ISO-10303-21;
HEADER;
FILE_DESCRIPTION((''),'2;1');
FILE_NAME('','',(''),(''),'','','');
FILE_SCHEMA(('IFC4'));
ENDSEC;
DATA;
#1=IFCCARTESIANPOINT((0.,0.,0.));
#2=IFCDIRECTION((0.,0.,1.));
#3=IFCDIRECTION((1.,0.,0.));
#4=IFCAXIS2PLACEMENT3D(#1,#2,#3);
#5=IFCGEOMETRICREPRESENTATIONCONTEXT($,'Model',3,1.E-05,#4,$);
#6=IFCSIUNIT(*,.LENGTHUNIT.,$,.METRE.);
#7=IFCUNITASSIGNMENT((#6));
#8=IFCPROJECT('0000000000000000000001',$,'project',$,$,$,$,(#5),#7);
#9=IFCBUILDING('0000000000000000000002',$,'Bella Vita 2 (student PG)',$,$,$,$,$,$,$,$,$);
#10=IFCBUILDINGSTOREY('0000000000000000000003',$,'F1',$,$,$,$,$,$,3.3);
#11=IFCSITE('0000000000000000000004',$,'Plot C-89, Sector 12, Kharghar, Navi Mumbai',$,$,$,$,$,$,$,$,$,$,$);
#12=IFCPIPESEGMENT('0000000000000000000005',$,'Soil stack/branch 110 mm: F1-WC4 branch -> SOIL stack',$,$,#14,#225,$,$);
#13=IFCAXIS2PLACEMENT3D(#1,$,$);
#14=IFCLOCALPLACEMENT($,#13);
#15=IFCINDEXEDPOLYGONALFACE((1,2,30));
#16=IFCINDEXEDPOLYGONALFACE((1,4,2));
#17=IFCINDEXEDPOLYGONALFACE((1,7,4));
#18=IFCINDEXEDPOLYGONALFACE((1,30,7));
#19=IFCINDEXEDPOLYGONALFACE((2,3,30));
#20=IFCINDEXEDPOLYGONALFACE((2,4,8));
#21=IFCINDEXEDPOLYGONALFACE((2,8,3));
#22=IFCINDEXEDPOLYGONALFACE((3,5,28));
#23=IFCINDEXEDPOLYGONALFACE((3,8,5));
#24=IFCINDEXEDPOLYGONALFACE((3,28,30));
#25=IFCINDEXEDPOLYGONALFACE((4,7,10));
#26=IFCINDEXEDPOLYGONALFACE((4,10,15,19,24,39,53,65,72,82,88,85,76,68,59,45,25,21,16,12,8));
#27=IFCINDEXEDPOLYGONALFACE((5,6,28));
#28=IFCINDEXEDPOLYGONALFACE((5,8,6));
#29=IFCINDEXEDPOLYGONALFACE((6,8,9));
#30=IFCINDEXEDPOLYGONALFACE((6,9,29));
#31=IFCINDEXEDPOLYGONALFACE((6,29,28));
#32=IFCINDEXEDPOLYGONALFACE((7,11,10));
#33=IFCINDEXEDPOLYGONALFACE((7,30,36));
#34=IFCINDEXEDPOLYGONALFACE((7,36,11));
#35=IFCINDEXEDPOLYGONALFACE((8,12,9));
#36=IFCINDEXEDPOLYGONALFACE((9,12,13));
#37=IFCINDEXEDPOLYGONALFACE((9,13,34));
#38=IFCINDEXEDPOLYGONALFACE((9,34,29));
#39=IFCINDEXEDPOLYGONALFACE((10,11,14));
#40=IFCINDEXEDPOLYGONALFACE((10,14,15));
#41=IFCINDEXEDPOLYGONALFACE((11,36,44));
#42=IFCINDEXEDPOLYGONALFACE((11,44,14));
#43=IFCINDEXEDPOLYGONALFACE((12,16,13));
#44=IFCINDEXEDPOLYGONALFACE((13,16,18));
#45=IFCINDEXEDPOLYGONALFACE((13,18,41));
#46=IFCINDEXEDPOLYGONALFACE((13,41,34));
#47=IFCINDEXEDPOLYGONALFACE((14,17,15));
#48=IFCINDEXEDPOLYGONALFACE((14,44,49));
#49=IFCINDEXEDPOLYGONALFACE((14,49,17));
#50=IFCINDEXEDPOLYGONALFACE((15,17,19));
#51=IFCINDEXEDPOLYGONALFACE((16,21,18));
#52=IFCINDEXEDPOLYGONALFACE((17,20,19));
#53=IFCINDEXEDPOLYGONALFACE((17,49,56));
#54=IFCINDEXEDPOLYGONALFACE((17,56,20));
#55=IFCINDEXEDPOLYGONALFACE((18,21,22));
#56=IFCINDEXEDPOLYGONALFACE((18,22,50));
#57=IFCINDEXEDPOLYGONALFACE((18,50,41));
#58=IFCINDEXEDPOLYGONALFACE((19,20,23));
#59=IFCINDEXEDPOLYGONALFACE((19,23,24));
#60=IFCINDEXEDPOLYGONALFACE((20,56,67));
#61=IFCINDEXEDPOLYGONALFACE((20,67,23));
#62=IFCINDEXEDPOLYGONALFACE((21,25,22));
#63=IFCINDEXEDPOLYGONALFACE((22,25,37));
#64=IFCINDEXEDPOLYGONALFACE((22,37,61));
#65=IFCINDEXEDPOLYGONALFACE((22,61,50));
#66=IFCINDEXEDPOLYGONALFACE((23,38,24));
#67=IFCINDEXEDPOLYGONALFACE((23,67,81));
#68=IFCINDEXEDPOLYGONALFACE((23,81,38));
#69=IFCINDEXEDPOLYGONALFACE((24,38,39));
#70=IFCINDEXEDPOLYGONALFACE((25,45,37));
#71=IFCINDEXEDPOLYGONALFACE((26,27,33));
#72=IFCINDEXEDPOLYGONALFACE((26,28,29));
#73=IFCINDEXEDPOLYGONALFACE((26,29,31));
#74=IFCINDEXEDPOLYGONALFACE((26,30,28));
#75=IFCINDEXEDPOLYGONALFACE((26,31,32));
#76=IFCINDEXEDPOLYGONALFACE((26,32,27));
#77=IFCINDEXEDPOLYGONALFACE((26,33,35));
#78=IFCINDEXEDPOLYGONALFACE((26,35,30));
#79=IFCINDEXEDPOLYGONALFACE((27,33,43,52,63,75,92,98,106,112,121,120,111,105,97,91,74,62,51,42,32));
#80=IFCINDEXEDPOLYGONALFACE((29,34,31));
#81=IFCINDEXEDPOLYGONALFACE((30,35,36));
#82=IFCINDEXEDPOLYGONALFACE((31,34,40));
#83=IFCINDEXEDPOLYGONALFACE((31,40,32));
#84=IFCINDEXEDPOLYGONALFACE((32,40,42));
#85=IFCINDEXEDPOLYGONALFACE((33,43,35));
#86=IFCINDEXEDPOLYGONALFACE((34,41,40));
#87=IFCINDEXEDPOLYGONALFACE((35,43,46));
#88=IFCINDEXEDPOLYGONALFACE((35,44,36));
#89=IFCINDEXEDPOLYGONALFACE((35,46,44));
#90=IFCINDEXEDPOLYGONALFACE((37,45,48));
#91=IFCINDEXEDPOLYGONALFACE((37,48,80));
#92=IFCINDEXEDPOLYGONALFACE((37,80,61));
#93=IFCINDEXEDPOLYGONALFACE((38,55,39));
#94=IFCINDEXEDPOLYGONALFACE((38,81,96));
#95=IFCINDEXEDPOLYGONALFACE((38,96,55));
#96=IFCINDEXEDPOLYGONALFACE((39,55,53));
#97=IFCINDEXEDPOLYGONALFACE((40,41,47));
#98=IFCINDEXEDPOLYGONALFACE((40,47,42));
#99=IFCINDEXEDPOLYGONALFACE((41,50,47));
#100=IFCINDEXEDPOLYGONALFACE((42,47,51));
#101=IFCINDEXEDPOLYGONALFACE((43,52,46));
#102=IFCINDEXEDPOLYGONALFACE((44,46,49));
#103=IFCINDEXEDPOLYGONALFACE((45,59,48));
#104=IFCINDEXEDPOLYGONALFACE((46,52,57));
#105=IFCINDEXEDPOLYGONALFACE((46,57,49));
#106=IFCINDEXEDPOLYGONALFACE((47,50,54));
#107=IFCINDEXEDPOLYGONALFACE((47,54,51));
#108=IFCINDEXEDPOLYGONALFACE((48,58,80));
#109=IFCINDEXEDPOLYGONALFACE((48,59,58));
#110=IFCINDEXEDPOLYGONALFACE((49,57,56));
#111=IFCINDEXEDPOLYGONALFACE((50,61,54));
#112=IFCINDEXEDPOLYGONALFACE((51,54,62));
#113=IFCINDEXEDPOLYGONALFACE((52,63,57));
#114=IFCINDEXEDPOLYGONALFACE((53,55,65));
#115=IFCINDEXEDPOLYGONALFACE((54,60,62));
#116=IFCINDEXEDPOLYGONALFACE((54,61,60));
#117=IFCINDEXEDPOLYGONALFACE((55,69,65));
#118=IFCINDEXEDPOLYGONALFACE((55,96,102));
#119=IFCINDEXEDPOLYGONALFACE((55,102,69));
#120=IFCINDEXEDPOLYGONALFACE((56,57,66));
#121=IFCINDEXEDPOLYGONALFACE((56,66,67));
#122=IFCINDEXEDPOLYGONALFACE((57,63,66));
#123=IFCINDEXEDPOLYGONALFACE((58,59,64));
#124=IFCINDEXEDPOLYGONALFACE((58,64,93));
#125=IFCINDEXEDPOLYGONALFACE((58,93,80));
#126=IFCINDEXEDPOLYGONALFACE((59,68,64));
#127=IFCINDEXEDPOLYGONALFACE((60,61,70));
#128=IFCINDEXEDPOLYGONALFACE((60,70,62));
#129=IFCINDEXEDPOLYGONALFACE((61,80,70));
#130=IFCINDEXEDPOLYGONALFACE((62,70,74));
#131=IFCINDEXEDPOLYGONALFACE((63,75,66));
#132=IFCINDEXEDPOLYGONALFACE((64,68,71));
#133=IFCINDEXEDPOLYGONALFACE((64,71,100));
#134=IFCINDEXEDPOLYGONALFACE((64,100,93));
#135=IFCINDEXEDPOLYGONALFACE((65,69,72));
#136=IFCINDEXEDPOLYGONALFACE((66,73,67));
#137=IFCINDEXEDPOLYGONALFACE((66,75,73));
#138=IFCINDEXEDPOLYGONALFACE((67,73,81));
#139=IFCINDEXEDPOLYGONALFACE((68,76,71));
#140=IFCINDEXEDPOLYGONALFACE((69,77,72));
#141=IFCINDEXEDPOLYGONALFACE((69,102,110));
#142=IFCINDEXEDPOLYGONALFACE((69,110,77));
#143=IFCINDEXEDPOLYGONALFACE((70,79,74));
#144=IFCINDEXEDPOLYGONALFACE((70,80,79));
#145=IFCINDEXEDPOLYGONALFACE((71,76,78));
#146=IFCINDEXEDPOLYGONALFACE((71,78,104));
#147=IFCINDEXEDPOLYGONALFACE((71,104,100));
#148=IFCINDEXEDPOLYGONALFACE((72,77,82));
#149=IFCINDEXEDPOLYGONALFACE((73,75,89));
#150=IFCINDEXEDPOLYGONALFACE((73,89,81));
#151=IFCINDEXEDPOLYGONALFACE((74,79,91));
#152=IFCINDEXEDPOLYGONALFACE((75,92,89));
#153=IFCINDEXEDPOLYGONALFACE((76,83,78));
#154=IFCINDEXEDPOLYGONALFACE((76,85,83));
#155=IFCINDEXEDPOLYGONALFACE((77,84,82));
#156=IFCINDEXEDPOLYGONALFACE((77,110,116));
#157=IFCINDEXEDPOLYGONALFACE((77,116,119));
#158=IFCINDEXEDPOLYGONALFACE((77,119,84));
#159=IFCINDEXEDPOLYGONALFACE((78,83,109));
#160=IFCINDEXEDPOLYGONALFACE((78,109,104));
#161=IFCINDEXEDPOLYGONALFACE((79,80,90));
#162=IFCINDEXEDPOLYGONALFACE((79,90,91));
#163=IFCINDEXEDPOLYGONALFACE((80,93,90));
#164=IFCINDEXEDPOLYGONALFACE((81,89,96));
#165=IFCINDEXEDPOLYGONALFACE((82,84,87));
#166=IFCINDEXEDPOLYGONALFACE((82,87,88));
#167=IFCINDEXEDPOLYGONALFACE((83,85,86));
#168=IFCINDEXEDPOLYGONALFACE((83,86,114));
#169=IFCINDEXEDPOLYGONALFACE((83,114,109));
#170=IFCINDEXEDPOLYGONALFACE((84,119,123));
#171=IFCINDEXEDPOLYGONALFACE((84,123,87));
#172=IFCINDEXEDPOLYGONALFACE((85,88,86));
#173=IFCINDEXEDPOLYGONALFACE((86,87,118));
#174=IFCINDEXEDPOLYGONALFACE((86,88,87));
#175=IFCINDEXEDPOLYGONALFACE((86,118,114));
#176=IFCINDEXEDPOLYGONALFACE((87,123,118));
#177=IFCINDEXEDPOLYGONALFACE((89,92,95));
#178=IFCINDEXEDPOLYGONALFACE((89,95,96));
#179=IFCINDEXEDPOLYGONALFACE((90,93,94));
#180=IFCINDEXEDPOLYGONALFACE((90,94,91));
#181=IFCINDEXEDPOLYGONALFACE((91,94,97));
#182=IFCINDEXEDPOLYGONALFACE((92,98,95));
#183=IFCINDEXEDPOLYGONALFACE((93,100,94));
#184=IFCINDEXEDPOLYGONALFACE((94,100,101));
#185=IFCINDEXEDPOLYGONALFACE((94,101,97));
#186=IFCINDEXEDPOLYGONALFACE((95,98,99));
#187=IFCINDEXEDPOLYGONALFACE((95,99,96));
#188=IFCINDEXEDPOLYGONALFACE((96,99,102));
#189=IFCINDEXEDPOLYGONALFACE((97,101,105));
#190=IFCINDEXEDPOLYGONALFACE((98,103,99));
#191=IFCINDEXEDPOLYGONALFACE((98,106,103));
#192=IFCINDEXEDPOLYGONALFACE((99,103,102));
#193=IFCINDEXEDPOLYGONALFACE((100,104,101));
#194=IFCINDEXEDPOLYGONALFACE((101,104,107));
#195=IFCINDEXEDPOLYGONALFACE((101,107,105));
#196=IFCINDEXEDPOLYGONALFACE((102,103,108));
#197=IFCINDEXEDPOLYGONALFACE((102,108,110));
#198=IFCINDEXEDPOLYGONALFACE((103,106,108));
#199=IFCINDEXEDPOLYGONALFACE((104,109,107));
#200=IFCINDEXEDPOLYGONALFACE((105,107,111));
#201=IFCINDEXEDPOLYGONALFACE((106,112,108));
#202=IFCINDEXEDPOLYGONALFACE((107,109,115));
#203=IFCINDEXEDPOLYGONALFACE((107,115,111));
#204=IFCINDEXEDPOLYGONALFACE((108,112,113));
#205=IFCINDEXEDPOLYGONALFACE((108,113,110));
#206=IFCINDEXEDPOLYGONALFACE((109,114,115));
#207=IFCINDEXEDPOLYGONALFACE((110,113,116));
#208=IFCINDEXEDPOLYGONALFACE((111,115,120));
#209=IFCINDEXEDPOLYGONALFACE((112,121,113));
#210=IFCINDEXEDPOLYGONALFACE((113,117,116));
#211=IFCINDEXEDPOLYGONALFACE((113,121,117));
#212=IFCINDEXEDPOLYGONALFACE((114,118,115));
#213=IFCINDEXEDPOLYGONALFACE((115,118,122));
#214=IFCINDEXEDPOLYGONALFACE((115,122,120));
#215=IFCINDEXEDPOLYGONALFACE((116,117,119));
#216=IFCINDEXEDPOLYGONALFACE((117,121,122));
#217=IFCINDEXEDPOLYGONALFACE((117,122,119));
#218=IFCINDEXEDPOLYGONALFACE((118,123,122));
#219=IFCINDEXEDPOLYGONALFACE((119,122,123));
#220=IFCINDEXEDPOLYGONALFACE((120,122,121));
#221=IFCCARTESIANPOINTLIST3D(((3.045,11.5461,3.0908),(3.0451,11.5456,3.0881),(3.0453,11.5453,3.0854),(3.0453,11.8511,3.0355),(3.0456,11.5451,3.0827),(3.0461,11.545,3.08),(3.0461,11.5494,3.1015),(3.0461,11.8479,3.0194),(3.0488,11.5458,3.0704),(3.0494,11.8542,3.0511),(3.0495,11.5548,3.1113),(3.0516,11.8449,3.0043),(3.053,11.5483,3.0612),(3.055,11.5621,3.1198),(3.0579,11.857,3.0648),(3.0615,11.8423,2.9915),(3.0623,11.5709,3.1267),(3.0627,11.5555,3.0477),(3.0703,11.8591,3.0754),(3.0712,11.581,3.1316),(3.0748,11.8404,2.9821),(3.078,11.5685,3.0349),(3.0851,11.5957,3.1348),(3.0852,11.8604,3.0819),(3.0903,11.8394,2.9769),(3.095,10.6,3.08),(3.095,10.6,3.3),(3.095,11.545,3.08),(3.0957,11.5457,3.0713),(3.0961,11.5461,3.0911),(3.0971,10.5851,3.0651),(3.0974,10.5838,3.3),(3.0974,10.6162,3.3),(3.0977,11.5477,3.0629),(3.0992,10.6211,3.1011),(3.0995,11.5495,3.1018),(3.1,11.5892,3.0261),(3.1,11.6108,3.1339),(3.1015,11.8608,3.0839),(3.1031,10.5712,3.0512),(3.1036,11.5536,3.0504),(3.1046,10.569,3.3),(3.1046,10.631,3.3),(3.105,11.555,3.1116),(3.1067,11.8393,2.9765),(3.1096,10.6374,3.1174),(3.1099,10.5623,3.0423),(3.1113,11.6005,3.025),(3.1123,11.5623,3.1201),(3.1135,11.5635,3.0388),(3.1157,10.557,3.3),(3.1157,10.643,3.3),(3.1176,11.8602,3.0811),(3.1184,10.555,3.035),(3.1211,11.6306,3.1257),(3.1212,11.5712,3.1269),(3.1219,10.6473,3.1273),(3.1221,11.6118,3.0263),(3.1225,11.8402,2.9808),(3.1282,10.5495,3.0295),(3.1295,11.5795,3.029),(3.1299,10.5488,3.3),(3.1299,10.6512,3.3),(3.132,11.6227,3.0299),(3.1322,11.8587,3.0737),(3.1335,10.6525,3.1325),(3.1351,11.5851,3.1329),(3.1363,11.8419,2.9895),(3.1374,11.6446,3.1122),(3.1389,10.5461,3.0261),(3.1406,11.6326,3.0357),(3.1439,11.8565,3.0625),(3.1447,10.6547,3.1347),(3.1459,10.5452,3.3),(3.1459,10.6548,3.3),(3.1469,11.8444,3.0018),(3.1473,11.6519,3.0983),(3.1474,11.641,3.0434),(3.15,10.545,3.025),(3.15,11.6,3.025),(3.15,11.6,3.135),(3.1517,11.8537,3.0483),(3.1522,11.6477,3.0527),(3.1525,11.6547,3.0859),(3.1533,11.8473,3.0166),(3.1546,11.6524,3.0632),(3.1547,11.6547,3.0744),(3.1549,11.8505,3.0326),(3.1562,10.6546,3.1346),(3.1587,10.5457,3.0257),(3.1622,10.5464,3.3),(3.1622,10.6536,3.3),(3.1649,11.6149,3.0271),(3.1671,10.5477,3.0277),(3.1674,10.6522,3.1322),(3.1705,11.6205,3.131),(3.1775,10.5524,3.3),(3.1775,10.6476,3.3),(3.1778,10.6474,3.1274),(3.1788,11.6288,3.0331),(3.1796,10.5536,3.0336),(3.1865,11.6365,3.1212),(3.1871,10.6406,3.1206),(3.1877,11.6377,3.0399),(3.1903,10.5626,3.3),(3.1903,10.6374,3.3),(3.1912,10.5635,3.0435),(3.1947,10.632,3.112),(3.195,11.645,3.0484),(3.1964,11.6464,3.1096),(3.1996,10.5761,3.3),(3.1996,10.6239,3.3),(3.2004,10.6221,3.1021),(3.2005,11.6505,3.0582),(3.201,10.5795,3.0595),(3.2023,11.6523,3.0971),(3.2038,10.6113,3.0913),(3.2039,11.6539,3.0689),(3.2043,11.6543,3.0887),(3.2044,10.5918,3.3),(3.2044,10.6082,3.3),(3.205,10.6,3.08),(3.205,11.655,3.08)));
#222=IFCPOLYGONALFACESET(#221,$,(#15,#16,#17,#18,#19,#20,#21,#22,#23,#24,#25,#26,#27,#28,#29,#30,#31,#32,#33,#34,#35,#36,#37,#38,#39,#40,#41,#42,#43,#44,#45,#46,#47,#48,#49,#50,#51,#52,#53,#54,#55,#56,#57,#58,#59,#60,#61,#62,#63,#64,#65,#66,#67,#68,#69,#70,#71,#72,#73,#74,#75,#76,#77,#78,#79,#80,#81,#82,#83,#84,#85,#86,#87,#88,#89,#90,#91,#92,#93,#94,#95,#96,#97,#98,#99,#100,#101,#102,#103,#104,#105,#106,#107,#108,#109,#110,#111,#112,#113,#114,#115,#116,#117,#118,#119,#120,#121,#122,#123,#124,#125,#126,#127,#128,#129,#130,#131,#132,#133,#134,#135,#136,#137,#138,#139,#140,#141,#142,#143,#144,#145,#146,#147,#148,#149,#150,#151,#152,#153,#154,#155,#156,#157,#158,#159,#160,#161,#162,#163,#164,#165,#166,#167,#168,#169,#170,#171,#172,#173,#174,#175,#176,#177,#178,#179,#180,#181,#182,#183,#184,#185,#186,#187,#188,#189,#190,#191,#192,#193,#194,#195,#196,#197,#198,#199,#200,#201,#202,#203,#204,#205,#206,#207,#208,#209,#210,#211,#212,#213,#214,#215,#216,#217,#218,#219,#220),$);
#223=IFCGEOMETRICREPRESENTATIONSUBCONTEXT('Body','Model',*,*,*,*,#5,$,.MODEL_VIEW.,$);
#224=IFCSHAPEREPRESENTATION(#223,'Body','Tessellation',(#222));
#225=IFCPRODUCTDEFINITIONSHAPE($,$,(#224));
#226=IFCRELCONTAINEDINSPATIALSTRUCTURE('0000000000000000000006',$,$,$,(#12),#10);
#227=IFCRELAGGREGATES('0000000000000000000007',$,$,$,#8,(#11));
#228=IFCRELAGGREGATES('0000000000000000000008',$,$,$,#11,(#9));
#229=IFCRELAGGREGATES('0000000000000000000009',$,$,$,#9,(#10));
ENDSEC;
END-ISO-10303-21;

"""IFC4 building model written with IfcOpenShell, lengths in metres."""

from ifc_helpers import new_model, entity, si_unit, origin, origin_with_axes, place, context, subcontext, project, spatial, element, save


model = new_model("IFC4")

# Units and contexts
model_context = context("Model", 3, precision=1e-05, world=origin_with_axes())
body_context = subcontext(model_context, "Body", "Model", "MODEL_VIEW")
ifc_project = project(units=[si_unit("LENGTHUNIT", "METRE")], contexts=[model_context])

# Site, building, storey
site = spatial("IfcSite", under=ifc_project, Name="Plot C-89, Sector 12, Kharghar, Navi Mumbai")
building = spatial("IfcBuilding", under=site, Name="Bella Vita 2 (student PG)")
storey = spatial("IfcBuildingStorey", under=building, Name="F1", Elevation=3.3)

# Pipe segment
pipe_segment_1_placement = place(None, origin())
element("IfcPipeSegment", 1, at=pipe_segment_1_placement, inside=storey, Name="Soil stack/branch 110 mm: F1-WC4 branch -> SOIL stack", context=body_context, shape_type="AdvancedSweptSolid", body=[
    entity("IfcSweptDiskSolid", entity("IfcPolyline", [entity("IfcCartesianPoint", [3.15, 10.6, 3.3]), entity("IfcCartesianPoint", [3.15, 10.6, 3.08]), entity("IfcCartesianPoint", [3.15, 11.6, 3.08]), entity("IfcCartesianPoint", [3.1, 11.6, 3.08]), entity("IfcCartesianPoint", [3.1, 11.85, 3.03])]), 0.055),
])

save(model, "model.ifc")
